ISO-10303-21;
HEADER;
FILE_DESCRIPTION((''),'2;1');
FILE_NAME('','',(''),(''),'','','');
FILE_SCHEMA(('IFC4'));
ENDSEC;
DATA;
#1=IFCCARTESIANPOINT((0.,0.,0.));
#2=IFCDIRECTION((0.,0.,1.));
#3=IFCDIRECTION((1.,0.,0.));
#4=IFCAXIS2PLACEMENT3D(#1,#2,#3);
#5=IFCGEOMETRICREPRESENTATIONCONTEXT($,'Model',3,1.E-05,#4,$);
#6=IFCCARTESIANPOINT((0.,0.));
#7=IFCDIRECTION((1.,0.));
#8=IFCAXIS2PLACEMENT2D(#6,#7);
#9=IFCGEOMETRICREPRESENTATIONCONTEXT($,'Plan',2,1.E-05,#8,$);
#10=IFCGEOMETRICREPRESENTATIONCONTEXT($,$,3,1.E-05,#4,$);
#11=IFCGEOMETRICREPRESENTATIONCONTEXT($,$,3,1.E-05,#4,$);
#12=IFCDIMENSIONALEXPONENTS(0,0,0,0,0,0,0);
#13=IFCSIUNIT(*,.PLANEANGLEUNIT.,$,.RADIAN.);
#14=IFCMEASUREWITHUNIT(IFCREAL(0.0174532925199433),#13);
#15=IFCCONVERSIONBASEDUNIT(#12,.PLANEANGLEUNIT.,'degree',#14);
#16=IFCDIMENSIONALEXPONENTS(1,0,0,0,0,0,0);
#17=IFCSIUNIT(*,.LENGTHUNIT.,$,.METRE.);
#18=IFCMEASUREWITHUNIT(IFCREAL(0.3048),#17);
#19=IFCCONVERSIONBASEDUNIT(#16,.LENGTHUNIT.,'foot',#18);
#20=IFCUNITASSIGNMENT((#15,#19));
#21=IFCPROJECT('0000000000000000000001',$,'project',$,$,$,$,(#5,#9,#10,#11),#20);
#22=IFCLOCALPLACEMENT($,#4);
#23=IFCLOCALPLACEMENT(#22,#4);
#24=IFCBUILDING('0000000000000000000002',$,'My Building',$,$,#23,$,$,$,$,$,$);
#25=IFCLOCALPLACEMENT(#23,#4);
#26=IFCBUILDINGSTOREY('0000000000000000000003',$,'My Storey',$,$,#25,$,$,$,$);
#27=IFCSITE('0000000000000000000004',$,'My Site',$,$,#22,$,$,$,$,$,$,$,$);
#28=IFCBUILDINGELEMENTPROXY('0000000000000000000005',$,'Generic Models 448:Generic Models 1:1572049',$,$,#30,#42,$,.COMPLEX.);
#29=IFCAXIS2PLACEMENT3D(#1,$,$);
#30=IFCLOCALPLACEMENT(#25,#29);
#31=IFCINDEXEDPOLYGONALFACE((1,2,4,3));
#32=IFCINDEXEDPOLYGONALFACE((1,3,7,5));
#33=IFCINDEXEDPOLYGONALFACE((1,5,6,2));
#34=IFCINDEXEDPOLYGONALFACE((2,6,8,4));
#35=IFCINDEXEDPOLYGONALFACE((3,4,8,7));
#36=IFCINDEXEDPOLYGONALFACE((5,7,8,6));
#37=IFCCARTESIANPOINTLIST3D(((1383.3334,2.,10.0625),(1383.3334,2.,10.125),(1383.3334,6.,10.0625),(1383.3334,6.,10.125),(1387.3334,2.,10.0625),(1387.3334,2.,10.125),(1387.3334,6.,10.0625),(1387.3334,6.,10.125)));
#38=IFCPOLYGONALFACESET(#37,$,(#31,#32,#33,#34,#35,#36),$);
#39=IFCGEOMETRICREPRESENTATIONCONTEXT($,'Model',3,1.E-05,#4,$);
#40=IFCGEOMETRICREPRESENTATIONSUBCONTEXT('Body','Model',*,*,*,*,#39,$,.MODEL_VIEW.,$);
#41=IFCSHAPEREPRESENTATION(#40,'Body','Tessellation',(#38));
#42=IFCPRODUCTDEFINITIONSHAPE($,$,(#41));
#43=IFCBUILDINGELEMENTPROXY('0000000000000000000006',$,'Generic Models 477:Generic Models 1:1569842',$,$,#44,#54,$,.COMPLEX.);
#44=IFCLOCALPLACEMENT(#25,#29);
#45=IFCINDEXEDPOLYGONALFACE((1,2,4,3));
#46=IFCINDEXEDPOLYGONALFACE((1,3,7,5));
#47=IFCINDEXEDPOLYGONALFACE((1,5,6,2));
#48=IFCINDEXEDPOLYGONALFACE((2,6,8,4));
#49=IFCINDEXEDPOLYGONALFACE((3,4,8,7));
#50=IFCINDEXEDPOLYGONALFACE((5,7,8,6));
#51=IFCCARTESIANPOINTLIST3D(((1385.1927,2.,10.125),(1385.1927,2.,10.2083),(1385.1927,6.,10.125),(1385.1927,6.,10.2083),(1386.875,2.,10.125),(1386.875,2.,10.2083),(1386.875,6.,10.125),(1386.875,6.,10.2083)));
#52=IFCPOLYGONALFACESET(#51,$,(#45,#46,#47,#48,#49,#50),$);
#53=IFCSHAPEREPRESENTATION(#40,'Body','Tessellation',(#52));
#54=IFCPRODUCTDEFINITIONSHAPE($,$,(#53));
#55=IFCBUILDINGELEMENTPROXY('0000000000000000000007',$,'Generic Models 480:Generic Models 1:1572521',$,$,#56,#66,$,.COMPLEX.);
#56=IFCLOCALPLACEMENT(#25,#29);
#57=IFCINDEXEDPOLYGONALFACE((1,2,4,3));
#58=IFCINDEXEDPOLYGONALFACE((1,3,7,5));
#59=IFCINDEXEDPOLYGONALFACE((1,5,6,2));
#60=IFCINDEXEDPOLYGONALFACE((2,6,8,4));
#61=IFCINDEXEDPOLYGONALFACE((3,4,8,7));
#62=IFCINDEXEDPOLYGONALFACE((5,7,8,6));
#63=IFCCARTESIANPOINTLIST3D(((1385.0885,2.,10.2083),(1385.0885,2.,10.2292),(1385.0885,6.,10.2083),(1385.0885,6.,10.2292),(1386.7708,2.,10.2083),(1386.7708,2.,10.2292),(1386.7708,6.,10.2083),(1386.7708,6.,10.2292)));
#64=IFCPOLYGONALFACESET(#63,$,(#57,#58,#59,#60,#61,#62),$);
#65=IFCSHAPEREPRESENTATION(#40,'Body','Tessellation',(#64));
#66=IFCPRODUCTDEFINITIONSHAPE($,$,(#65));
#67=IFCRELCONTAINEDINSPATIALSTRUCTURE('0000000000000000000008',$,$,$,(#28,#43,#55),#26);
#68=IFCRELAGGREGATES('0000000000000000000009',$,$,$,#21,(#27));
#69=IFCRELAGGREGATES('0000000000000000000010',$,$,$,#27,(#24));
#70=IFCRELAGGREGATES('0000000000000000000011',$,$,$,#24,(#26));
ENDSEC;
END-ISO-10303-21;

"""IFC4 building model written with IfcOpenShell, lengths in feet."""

from ifc_helpers import new_model, entity, si_unit, converted_unit, frame, origin_with_axes, origin_2d_with_axis, place, context, subcontext, project, spatial, polyline, outline, extrude, element, save


model = new_model("IFC4")

# Units and contexts
model_context_1 = context("Model", 3, precision=1e-05, world=origin_with_axes())
plan_context = context("Plan", 2, precision=1e-05, world=origin_2d_with_axis())
model_context_2 = context("Model", 3, precision=1e-05, world=origin_with_axes())
context_of_model_1 = context(None, 3, precision=1e-05, world=origin_with_axes())
context_of_model_2 = context(None, 3, precision=1e-05, world=origin_with_axes())
body_context = subcontext(model_context_2, "Body", "Model", "MODEL_VIEW")
ifc_project = project(units=[converted_unit("PLANEANGLEUNIT", "degree", entity("IfcReal", 0.0174532925199433), si_unit("PLANEANGLEUNIT", "RADIAN"), dimensions=[0, 0, 0, 0, 0, 0, 0]), converted_unit("LENGTHUNIT", "foot", entity("IfcReal", 0.3048), si_unit("LENGTHUNIT", "METRE"), dimensions=[1, 0, 0, 0, 0, 0, 0])], contexts=[model_context_1, plan_context, context_of_model_1, context_of_model_2])

# Site, building, storey
site_placement = place(None, origin_with_axes())
site = spatial("IfcSite", under=ifc_project, at=site_placement, Name="My Site")
building_placement = place(site_placement, origin_with_axes())
building = spatial("IfcBuilding", under=site, at=building_placement, Name="My Building")
storey_placement = place(building_placement, origin_with_axes())
storey = spatial("IfcBuildingStorey", under=building, at=storey_placement, Name="My Storey")

# Building element proxies
proxy_1_placement = place(storey_placement, frame((1383.3334, 6.0, 10.0625), z_axis=(0.0, -1.0, 0.0), x_axis=(0.0, 0.0, 1.0)))
element("IfcBuildingElementProxy", 1, at=proxy_1_placement, inside=storey, Name="Generic Models 448:Generic Models 1:1572049", PredefinedType="COMPLEX", context=body_context, shape_type="SweptSolid", body=[
    extrude(outline(polyline([(-0.0313, -2.0), (0.0313, -2.0), (0.0312, 2.0), (-0.0313, 2.0), (-0.0313, -2.0)])), frame((0.0313, -2.0, 0.0), z_axis=(0.0, 0.0, -1.0), x_axis=(1.0, 0.0, 0.0)), (0.0, 0.0, -1.0), 4.0),
])
proxy_2_placement = place(storey_placement, frame((1385.1927, 6.0, 10.125), z_axis=(0.0, -1.0, 0.0), x_axis=(0.0, 0.0, 1.0)))
element("IfcBuildingElementProxy", 2, at=proxy_2_placement, inside=storey, Name="Generic Models 477:Generic Models 1:1569842", PredefinedType="COMPLEX", context=body_context, shape_type="SweptSolid", body=[
    extrude(outline(polyline([(-0.8411, -0.0417), (0.8411, -0.0417), (0.8411, 0.0417), (-0.8411, 0.0417), (-0.8411, -0.0417)])), frame((0.0417, -0.8411, 0.0), z_axis=(0.0, 0.0, -1.0), x_axis=(0.0, 1.0, 0.0)), (0.0, 0.0, -1.0), 4.0),
])
proxy_3_placement = place(storey_placement, frame((1385.0885, 6.0, 10.2083), z_axis=(0.0, -1.0, 0.0), x_axis=(0.0, 0.0, 1.0)))
element("IfcBuildingElementProxy", 3, at=proxy_3_placement, inside=storey, Name="Generic Models 480:Generic Models 1:1572521", PredefinedType="COMPLEX", context=body_context, shape_type="SweptSolid", body=[
    extrude(outline(polyline([(0.8412, 0.0), (0.841, 0.0208), (-0.8412, 0.0), (-0.841, -0.0208), (0.8412, 0.0)])), frame((0.0104, -0.8411, 0.0), z_axis=(0.0, 0.0, -1.0), x_axis=(-0.012383, 0.999923, 0.0)), (0.0, 0.0, -1.0), 4.0),
])

save(model, "model.ifc")
